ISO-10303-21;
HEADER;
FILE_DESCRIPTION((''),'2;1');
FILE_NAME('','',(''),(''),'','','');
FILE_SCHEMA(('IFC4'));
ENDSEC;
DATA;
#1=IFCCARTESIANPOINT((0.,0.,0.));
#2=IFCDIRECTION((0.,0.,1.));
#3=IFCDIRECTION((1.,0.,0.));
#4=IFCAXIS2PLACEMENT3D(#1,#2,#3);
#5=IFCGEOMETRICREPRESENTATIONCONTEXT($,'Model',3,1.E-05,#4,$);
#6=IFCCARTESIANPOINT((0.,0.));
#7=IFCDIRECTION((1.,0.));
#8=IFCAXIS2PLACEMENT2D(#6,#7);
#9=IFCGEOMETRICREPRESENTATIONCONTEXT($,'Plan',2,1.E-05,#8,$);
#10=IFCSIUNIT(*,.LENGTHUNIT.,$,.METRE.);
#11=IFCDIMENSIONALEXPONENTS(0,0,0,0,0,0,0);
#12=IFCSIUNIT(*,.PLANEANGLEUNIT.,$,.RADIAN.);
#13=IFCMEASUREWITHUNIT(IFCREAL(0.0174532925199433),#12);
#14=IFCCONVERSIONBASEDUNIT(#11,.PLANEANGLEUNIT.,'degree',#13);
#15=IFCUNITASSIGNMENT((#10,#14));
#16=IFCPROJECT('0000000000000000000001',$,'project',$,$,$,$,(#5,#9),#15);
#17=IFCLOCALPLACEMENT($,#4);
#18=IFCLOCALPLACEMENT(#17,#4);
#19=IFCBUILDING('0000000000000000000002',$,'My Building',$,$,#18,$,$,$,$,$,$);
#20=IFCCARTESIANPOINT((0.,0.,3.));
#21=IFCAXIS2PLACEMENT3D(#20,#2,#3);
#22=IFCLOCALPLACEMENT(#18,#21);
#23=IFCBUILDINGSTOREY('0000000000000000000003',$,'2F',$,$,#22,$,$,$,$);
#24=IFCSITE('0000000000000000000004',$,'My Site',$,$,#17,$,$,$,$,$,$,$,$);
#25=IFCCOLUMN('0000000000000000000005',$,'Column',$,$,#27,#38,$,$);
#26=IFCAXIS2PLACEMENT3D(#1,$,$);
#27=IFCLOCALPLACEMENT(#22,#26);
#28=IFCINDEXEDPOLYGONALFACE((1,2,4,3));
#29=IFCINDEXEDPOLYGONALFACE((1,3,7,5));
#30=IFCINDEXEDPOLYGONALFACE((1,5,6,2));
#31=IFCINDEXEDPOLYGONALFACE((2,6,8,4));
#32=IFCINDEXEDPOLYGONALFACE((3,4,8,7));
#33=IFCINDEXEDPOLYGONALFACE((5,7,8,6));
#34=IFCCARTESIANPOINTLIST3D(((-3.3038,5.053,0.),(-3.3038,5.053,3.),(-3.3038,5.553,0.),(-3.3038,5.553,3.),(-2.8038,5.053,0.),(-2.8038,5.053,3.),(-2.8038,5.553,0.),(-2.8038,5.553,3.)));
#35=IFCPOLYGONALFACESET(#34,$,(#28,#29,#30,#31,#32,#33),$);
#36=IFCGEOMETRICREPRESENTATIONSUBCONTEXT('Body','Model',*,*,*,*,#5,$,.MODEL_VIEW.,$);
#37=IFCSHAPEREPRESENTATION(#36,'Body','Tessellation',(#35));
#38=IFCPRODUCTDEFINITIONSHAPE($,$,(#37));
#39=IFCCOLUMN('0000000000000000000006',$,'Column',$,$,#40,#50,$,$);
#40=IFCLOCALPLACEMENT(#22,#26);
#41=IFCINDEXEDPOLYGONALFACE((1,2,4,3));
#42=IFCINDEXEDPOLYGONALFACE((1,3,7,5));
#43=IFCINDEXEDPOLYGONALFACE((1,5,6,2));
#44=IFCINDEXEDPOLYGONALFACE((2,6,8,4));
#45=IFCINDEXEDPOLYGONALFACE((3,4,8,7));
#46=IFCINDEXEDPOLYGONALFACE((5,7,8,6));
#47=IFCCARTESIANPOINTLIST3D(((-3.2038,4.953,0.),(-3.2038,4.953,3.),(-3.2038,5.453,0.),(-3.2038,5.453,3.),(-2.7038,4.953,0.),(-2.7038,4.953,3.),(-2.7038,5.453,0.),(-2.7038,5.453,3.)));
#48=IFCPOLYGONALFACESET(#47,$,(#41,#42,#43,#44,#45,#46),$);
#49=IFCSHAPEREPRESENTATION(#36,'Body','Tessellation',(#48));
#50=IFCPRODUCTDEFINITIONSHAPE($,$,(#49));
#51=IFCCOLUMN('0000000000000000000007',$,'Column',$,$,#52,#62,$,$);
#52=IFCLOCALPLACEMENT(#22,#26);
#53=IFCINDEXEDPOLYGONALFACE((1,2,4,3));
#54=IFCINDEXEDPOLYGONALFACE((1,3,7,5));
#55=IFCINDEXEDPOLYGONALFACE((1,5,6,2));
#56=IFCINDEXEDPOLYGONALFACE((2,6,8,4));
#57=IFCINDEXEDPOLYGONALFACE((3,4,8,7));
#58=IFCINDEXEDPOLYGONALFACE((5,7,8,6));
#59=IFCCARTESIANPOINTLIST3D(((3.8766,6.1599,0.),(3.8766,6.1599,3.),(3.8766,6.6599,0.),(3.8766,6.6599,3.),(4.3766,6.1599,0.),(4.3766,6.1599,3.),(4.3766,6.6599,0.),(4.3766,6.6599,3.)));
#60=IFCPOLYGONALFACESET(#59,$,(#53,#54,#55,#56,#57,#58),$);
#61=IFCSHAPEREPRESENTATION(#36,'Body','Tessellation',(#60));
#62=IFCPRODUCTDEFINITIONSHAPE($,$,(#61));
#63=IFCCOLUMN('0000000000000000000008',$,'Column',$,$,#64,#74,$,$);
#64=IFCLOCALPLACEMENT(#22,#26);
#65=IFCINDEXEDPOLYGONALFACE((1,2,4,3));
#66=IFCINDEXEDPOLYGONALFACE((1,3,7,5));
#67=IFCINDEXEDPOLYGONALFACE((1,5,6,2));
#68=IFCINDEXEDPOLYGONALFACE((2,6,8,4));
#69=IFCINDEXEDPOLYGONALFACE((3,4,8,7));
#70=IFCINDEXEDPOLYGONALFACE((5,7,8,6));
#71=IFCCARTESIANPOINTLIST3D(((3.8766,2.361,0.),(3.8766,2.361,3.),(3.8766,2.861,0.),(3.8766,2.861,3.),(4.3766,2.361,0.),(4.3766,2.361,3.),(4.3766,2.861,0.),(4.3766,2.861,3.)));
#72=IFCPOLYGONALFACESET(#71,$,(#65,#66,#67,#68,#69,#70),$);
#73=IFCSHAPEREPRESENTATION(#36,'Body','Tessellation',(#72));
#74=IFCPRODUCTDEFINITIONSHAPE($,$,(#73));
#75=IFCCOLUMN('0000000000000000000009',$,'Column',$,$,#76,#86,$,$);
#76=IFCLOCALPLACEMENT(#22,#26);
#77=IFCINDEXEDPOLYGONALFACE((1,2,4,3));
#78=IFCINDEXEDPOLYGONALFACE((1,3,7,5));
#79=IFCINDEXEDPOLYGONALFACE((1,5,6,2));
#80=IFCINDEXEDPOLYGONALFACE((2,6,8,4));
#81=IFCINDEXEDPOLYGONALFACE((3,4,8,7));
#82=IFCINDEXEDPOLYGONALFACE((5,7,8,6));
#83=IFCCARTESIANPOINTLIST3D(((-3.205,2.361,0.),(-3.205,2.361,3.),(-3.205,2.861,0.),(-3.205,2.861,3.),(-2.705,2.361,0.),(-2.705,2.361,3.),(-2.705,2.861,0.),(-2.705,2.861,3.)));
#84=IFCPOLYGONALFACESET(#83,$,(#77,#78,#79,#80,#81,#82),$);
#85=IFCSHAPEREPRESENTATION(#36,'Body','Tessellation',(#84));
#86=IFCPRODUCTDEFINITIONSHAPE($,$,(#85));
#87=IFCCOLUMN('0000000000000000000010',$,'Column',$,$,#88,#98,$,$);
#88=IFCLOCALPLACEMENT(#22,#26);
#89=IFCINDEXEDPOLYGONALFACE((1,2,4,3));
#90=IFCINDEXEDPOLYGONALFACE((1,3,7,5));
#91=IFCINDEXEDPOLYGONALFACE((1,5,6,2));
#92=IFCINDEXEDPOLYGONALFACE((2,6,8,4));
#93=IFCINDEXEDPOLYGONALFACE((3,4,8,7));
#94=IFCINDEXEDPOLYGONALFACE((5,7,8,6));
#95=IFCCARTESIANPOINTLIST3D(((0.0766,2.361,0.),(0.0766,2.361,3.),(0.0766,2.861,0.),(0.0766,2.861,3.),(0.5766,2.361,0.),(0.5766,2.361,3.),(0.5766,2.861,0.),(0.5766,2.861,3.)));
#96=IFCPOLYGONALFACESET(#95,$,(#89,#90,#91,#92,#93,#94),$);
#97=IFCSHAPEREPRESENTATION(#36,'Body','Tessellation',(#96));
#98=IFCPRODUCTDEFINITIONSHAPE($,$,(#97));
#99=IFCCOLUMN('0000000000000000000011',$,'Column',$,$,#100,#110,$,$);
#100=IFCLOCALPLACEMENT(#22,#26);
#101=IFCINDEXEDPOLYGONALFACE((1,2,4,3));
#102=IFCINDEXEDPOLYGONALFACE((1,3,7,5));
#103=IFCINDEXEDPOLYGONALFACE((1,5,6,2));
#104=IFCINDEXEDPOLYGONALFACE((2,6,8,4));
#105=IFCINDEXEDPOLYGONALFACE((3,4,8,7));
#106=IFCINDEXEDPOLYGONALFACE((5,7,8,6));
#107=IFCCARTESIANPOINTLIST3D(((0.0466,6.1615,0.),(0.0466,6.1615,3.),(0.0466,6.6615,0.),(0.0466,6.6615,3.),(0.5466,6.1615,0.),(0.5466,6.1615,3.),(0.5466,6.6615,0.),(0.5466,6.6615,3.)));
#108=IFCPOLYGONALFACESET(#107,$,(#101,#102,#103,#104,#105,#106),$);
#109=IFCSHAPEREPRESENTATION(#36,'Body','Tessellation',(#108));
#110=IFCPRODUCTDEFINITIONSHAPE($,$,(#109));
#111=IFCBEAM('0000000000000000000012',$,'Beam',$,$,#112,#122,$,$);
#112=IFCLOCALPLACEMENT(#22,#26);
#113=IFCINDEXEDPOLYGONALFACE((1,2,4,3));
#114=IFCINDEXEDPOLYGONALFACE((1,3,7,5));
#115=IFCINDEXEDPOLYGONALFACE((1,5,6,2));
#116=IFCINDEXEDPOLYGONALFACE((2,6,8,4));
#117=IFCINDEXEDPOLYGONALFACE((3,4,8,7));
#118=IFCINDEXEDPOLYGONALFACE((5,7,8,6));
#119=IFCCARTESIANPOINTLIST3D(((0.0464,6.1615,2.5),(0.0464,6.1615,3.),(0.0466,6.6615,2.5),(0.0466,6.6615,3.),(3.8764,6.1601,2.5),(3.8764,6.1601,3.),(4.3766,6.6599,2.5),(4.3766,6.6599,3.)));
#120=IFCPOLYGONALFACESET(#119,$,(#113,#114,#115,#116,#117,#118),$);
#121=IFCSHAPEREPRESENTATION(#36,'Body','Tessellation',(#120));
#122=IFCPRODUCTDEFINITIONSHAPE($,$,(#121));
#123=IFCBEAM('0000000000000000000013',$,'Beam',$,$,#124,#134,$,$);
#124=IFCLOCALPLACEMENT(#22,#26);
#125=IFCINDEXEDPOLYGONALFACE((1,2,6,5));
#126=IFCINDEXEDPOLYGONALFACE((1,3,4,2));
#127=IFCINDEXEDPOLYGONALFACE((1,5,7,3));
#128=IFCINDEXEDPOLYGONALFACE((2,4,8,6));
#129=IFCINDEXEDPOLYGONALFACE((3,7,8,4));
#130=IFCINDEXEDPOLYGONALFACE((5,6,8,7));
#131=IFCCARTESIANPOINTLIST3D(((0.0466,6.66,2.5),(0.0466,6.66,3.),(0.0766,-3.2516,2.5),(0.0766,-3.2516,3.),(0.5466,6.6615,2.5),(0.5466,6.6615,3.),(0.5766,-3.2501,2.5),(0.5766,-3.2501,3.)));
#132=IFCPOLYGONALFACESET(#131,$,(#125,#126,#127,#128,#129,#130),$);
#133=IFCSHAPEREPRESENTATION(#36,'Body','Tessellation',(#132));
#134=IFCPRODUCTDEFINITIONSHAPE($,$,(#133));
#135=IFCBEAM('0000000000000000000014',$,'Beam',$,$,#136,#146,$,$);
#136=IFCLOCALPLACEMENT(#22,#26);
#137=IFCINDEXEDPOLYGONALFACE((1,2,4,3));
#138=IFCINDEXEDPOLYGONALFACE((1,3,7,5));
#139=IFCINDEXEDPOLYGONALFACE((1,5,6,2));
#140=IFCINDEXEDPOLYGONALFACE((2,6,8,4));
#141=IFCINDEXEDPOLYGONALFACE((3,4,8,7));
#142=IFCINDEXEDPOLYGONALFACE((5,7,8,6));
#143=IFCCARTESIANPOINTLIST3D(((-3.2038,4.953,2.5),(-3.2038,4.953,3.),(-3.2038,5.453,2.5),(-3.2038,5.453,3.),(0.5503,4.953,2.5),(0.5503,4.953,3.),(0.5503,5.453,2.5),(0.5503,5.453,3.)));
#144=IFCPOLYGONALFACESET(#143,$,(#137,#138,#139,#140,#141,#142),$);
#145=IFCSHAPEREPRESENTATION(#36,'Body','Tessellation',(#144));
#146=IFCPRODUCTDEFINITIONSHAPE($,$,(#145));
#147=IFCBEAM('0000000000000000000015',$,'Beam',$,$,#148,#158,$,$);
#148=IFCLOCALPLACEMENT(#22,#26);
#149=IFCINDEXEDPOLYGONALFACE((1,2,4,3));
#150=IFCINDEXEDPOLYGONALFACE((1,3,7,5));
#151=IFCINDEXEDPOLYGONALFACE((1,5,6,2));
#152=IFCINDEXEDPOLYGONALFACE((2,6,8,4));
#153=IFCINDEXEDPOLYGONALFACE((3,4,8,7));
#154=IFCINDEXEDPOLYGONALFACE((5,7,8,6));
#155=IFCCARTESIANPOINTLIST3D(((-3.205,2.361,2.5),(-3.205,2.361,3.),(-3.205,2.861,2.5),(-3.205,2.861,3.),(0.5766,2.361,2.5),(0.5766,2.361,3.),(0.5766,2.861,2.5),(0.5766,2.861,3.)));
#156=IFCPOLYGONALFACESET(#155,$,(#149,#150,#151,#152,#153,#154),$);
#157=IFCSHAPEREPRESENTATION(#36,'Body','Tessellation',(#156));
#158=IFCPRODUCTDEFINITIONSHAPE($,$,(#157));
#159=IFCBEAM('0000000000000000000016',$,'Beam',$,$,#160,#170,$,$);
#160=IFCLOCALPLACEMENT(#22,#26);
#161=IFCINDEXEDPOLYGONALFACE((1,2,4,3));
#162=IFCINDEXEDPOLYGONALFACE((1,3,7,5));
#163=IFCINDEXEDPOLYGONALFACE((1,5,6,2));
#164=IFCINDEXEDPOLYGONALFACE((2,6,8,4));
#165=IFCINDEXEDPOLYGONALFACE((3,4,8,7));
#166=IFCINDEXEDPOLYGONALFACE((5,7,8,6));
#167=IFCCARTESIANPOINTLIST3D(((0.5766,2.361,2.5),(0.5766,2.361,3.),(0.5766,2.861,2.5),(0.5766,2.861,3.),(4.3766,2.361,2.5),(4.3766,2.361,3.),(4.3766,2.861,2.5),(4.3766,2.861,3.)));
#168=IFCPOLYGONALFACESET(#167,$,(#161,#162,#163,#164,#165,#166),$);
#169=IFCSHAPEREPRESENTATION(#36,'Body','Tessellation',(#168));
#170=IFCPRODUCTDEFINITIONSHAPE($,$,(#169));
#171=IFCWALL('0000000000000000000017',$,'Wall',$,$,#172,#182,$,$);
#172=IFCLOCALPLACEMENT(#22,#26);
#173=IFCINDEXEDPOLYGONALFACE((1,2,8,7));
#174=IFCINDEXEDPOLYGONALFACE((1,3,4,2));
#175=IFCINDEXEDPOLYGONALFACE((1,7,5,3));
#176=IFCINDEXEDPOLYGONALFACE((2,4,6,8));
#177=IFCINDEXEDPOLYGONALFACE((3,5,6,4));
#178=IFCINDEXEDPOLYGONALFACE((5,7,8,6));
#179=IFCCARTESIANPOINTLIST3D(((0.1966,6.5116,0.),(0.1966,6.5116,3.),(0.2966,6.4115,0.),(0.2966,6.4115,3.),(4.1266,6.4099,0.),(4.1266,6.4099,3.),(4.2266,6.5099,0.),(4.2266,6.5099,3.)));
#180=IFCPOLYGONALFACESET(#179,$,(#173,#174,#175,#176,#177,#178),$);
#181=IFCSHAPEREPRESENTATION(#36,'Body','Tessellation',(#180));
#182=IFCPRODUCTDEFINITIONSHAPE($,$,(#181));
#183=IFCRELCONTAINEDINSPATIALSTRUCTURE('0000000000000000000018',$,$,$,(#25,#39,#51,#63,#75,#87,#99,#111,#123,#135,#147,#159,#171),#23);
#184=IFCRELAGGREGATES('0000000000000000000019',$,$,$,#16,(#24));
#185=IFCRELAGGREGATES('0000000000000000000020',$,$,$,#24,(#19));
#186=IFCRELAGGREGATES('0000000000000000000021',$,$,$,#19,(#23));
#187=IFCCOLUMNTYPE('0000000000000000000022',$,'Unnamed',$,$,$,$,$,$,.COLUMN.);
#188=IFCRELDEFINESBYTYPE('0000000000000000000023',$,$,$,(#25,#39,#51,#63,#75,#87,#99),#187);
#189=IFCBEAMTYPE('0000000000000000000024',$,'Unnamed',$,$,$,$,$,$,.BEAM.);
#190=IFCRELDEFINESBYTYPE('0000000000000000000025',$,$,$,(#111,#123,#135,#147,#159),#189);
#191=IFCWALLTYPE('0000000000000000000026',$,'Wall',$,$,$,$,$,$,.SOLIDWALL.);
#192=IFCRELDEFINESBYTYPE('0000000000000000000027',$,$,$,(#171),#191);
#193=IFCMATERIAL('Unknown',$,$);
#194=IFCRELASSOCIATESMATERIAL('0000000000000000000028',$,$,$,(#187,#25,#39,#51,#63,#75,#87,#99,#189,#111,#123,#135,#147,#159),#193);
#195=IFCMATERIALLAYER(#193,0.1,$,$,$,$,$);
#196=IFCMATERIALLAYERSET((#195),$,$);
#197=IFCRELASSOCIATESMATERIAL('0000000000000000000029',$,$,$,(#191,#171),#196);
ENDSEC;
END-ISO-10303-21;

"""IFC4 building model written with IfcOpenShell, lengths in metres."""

from ifc_helpers import new_model, entity, si_unit, converted_unit, frame, origin_with_axes, origin_2d_with_axis, place, context, subcontext, project, spatial, line, indexed_curve, rectangle, outline, extrude, clip, halfspace, material, layer, layer_set, layer_usage, material_profile, profile_set, profile_usage, type_object, element, save


model = new_model("IFC4")

# Units and contexts
model_context = context("Model", 3, precision=1e-05, world=origin_with_axes())
plan_context = context("Plan", 2, precision=1e-05, world=origin_2d_with_axis())
body_context_1 = subcontext(model_context, "Body", "Model", "MODEL_VIEW")
ifc_project = project(units=[si_unit("LENGTHUNIT", "METRE"), converted_unit("PLANEANGLEUNIT", "degree", entity("IfcReal", 0.0174532925199433), si_unit("PLANEANGLEUNIT", "RADIAN"), dimensions=[0, 0, 0, 0, 0, 0, 0])], contexts=[model_context, plan_context])

# Site, building, storey
site_placement = place(None, origin_with_axes())
site = spatial("IfcSite", under=ifc_project, at=site_placement, Name="My Site")
building_placement = place(site_placement, origin_with_axes())
building = spatial("IfcBuilding", under=site, at=building_placement, Name="My Building")
storey_placement = place(building_placement, frame((0.0, 0.0, 3.0), z_axis=(0.0, 0.0, 1.0), x_axis=(1.0, 0.0, 0.0)))
storey = spatial("IfcBuildingStorey", under=building, at=storey_placement, Name="2F")

# Columns
ifc_material = material(Name="Unknown")
ifc_material_profile_1 = material_profile(ifc_material, rectangle(XDim=0.5, YDim=0.5))
ifc_profile_set_1 = profile_set([ifc_material_profile_1])
ifc_profile_usage_1 = profile_usage(ifc_profile_set_1, cardinal=9)
column_type = type_object("IfcColumnType", Name="Unnamed", PredefinedType="COLUMN", material=ifc_profile_set_1)
column_1_placement = place(storey_placement, frame((-3.3038, 5.553, 0.0), z_axis=(0.0, 0.0, 1.0), x_axis=(1.0, 0.0, 0.0)))
element("IfcColumn", 1, at=column_1_placement, inside=storey, type_object=column_type, material=ifc_profile_usage_1, Name="Column", context=body_context_1, shape_type="SweptSolid", body=[
    extrude(rectangle(XDim=0.5, YDim=0.5), frame((0.25, -0.25, 0.0), z_axis=(0.0, 0.0, 1.0), x_axis=(1.0, 0.0, 0.0)), (0.0, 0.0, 1.0), 3.0),
])
ifc_profile_usage_2 = profile_usage(ifc_profile_set_1, cardinal=9)
column_2_placement = place(storey_placement, frame((-3.2038, 5.453, 0.0), z_axis=(0.0, 0.0, 1.0), x_axis=(1.0, 0.0, 0.0)))
element("IfcColumn", 2, at=column_2_placement, inside=storey, type_object=column_type, material=ifc_profile_usage_2, Name="Column", context=body_context_1, shape_type="SweptSolid", body=[
    extrude(rectangle(XDim=0.5, YDim=0.5), frame((0.25, -0.25, 0.0), z_axis=(0.0, 0.0, 1.0), x_axis=(1.0, 0.0, 0.0)), (0.0, 0.0, 1.0), 3.0),
])
ifc_profile_usage_3 = profile_usage(ifc_profile_set_1, cardinal=9)
column_3_placement = place(storey_placement, frame((3.8766, 6.6599, 0.0), z_axis=(0.0, 0.0, 1.0), x_axis=(1.0, 0.0, 0.0)))
element("IfcColumn", 3, at=column_3_placement, inside=storey, type_object=column_type, material=ifc_profile_usage_3, Name="Column", context=body_context_1, shape_type="SweptSolid", body=[
    extrude(rectangle(XDim=0.5, YDim=0.5), frame((0.25, -0.25, 0.0), z_axis=(0.0, 0.0, 1.0), x_axis=(1.0, 0.0, 0.0)), (0.0, 0.0, 1.0), 3.0),
])
ifc_profile_usage_4 = profile_usage(ifc_profile_set_1, cardinal=7)
column_4_placement = place(storey_placement, frame((4.3766, 2.861, 0.0), z_axis=(0.0, 0.0, 1.0), x_axis=(1.0, 0.0, 0.0)))
element("IfcColumn", 4, at=column_4_placement, inside=storey, type_object=column_type, material=ifc_profile_usage_4, Name="Column", context=body_context_1, shape_type="SweptSolid", body=[
    extrude(rectangle(XDim=0.5, YDim=0.5), frame((-0.25, -0.25, 0.0), z_axis=(0.0, 0.0, 1.0), x_axis=(1.0, 0.0, 0.0)), (0.0, 0.0, 1.0), 3.0),
])
ifc_profile_usage_5 = profile_usage(ifc_profile_set_1, cardinal=7)
column_5_placement = place(storey_placement, frame((-2.705, 2.861, 0.0), z_axis=(0.0, 0.0, 1.0), x_axis=(1.0, 0.0, 0.0)))
element("IfcColumn", 5, at=column_5_placement, inside=storey, type_object=column_type, material=ifc_profile_usage_5, Name="Column", context=body_context_1, shape_type="SweptSolid", body=[
    extrude(rectangle(XDim=0.5, YDim=0.5), frame((-0.25, -0.25, 0.0), z_axis=(0.0, 0.0, 1.0), x_axis=(1.0, 0.0, 0.0)), (0.0, 0.0, 1.0), 3.0),
])
ifc_profile_usage_6 = profile_usage(ifc_profile_set_1, cardinal=7)
column_6_placement = place(storey_placement, frame((0.5766, 2.861, 0.0), z_axis=(0.0, 0.0, 1.0), x_axis=(1.0, 0.0, 0.0)))
element("IfcColumn", 6, at=column_6_placement, inside=storey, type_object=column_type, material=ifc_profile_usage_6, Name="Column", context=body_context_1, shape_type="SweptSolid", body=[
    extrude(rectangle(XDim=0.5, YDim=0.5), frame((-0.25, -0.25, 0.0), z_axis=(0.0, 0.0, 1.0), x_axis=(1.0, 0.0, 0.0)), (0.0, 0.0, 1.0), 3.0),
])
ifc_profile_usage_7 = profile_usage(ifc_profile_set_1, cardinal=7)
column_7_placement = place(storey_placement, frame((0.5466, 6.6615, 0.0), z_axis=(0.0, 0.0, 1.0), x_axis=(1.0, 0.0, 0.0)))
element("IfcColumn", 7, at=column_7_placement, inside=storey, type_object=column_type, material=ifc_profile_usage_7, Name="Column", context=body_context_1, shape_type="SweptSolid", body=[
    extrude(rectangle(XDim=0.5, YDim=0.5), frame((-0.25, -0.25, 0.0), z_axis=(0.0, 0.0, 1.0), x_axis=(1.0, 0.0, 0.0)), (0.0, 0.0, 1.0), 3.0),
])

# Beams
ifc_material_profile_2 = material_profile(ifc_material, rectangle(XDim=0.5, YDim=0.5))
ifc_profile_set_2 = profile_set([ifc_material_profile_2])
ifc_profile_usage_8 = profile_usage(ifc_profile_set_2, cardinal=7)
beam_type = type_object("IfcBeamType", Name="Unnamed", PredefinedType="BEAM", material=ifc_profile_set_2)
beam_1_placement = place(storey_placement, frame((0.0466, 6.6615, 3.0), z_axis=(1.0, -0.000377, 0.0), x_axis=(0.000377, 1.0, 0.0)))
element("IfcBeam", 8, at=beam_1_placement, inside=storey, type_object=beam_type, material=ifc_profile_usage_8, Name="Beam", context=body_context_1, shape_type="Clipping", body=[
    clip(extrude(rectangle(XDim=0.5, YDim=0.5), frame((-0.25, -0.25, 0.0), z_axis=(0.0, 0.0, 1.0), x_axis=(1.0, 0.0, 0.0)), (0.0, 0.0, 1.0), 4.83), halfspace(frame((0.0, -6.0, 4.33), z_axis=(-0.707114, 0.0, 0.707099), x_axis=(0.0, 1.0, 0.0)), False)),
])
ifc_profile_usage_9 = profile_usage(ifc_profile_set_2, cardinal=7)
beam_2_placement = place(storey_placement, frame((0.5466, 6.6615, 3.0), z_axis=(0.003031, -0.999995, 0.0), x_axis=(0.999995, 0.003031, 0.0)))
element("IfcBeam", 9, at=beam_2_placement, inside=storey, type_object=beam_type, material=ifc_profile_usage_9, Name="Beam", context=body_context_1, shape_type="SweptSolid", body=[
    extrude(rectangle(XDim=0.5, YDim=0.5), frame((-0.25, -0.25, 0.0), z_axis=(0.0, 0.0, 1.0), x_axis=(1.0, 0.0, 0.0)), (0.0, 0.0, 1.0), 9.9117),
])
ifc_profile_usage_10 = profile_usage(ifc_profile_set_2, cardinal=7)
beam_3_placement = place(storey_placement, frame((-3.2038, 5.453, 3.0), z_axis=(1.0, 0.0, 0.000001), x_axis=(0.0, 1.0, 0.0)))
element("IfcBeam", 10, at=beam_3_placement, inside=storey, type_object=beam_type, material=ifc_profile_usage_10, Name="Beam", context=body_context_1, shape_type="SweptSolid", body=[
    extrude(rectangle(XDim=0.5, YDim=0.5), frame((-0.25, -0.25, 0.0), z_axis=(0.0, 0.0, 1.0), x_axis=(1.0, 0.0, 0.0)), (0.0, 0.0, 1.0), 3.7541),
])
ifc_profile_usage_11 = profile_usage(ifc_profile_set_2, cardinal=7)
beam_4_placement = place(storey_placement, frame((-3.205, 2.861, 3.0), z_axis=(1.0, 0.0, 0.0), x_axis=(0.0, 1.0, 0.0)))
element("IfcBeam", 11, at=beam_4_placement, inside=storey, type_object=beam_type, material=ifc_profile_usage_11, Name="Beam", context=body_context_1, shape_type="SweptSolid", body=[
    extrude(rectangle(XDim=0.5, YDim=0.5), frame((-0.25, -0.25, 0.0), z_axis=(0.0, 0.0, 1.0), x_axis=(1.0, 0.0, 0.0)), (0.0, 0.0, 1.0), 3.7816),
])
ifc_profile_usage_12 = profile_usage(ifc_profile_set_2, cardinal=7)
beam_5_placement = place(storey_placement, frame((0.5766, 2.861, 3.0), z_axis=(1.0, 0.000001, 0.0), x_axis=(-0.000001, 1.0, 0.0)))
element("IfcBeam", 12, at=beam_5_placement, inside=storey, type_object=beam_type, material=ifc_profile_usage_12, Name="Beam", context=body_context_1, shape_type="SweptSolid", body=[
    extrude(rectangle(XDim=0.5, YDim=0.5), frame((-0.25, -0.25, 0.0), z_axis=(0.0, 0.0, 1.0), x_axis=(1.0, 0.0, 0.0)), (0.0, 0.0, 1.0), 3.8),
])

# Wall
ifc_layer = layer(ifc_material, 0.1)
ifc_layer_set = layer_set([ifc_layer])
ifc_layer_usage_1 = layer_usage(ifc_layer_set, "AXIS2", "POSITIVE", 0.0)
wall_type = type_object("IfcWallType", Name="Wall", PredefinedType="SOLIDWALL", material=ifc_layer_set)
wall_1_placement = place(storey_placement, frame((4.2266, 6.5099, 0.0), z_axis=(0.0, 0.0, 1.0), x_axis=(-1.0, 0.000415, 0.0)))
element("IfcWall", 13, at=wall_1_placement, inside=storey, type_object=wall_type, material=ifc_layer_usage_1, Name="Wall", context=body_context_1, shape_type="SweptSolid", body=[
    extrude(outline(indexed_curve([(0.0, 0.0), (0.1, 0.1), (3.93, 0.1), (4.03, 0.0)], segments=[line(1, 2, 3, 4, 1)])), origin_with_axes(), (0.0, 0.0, 1.0), 3.0),
])

save(model, "model.ifc")
